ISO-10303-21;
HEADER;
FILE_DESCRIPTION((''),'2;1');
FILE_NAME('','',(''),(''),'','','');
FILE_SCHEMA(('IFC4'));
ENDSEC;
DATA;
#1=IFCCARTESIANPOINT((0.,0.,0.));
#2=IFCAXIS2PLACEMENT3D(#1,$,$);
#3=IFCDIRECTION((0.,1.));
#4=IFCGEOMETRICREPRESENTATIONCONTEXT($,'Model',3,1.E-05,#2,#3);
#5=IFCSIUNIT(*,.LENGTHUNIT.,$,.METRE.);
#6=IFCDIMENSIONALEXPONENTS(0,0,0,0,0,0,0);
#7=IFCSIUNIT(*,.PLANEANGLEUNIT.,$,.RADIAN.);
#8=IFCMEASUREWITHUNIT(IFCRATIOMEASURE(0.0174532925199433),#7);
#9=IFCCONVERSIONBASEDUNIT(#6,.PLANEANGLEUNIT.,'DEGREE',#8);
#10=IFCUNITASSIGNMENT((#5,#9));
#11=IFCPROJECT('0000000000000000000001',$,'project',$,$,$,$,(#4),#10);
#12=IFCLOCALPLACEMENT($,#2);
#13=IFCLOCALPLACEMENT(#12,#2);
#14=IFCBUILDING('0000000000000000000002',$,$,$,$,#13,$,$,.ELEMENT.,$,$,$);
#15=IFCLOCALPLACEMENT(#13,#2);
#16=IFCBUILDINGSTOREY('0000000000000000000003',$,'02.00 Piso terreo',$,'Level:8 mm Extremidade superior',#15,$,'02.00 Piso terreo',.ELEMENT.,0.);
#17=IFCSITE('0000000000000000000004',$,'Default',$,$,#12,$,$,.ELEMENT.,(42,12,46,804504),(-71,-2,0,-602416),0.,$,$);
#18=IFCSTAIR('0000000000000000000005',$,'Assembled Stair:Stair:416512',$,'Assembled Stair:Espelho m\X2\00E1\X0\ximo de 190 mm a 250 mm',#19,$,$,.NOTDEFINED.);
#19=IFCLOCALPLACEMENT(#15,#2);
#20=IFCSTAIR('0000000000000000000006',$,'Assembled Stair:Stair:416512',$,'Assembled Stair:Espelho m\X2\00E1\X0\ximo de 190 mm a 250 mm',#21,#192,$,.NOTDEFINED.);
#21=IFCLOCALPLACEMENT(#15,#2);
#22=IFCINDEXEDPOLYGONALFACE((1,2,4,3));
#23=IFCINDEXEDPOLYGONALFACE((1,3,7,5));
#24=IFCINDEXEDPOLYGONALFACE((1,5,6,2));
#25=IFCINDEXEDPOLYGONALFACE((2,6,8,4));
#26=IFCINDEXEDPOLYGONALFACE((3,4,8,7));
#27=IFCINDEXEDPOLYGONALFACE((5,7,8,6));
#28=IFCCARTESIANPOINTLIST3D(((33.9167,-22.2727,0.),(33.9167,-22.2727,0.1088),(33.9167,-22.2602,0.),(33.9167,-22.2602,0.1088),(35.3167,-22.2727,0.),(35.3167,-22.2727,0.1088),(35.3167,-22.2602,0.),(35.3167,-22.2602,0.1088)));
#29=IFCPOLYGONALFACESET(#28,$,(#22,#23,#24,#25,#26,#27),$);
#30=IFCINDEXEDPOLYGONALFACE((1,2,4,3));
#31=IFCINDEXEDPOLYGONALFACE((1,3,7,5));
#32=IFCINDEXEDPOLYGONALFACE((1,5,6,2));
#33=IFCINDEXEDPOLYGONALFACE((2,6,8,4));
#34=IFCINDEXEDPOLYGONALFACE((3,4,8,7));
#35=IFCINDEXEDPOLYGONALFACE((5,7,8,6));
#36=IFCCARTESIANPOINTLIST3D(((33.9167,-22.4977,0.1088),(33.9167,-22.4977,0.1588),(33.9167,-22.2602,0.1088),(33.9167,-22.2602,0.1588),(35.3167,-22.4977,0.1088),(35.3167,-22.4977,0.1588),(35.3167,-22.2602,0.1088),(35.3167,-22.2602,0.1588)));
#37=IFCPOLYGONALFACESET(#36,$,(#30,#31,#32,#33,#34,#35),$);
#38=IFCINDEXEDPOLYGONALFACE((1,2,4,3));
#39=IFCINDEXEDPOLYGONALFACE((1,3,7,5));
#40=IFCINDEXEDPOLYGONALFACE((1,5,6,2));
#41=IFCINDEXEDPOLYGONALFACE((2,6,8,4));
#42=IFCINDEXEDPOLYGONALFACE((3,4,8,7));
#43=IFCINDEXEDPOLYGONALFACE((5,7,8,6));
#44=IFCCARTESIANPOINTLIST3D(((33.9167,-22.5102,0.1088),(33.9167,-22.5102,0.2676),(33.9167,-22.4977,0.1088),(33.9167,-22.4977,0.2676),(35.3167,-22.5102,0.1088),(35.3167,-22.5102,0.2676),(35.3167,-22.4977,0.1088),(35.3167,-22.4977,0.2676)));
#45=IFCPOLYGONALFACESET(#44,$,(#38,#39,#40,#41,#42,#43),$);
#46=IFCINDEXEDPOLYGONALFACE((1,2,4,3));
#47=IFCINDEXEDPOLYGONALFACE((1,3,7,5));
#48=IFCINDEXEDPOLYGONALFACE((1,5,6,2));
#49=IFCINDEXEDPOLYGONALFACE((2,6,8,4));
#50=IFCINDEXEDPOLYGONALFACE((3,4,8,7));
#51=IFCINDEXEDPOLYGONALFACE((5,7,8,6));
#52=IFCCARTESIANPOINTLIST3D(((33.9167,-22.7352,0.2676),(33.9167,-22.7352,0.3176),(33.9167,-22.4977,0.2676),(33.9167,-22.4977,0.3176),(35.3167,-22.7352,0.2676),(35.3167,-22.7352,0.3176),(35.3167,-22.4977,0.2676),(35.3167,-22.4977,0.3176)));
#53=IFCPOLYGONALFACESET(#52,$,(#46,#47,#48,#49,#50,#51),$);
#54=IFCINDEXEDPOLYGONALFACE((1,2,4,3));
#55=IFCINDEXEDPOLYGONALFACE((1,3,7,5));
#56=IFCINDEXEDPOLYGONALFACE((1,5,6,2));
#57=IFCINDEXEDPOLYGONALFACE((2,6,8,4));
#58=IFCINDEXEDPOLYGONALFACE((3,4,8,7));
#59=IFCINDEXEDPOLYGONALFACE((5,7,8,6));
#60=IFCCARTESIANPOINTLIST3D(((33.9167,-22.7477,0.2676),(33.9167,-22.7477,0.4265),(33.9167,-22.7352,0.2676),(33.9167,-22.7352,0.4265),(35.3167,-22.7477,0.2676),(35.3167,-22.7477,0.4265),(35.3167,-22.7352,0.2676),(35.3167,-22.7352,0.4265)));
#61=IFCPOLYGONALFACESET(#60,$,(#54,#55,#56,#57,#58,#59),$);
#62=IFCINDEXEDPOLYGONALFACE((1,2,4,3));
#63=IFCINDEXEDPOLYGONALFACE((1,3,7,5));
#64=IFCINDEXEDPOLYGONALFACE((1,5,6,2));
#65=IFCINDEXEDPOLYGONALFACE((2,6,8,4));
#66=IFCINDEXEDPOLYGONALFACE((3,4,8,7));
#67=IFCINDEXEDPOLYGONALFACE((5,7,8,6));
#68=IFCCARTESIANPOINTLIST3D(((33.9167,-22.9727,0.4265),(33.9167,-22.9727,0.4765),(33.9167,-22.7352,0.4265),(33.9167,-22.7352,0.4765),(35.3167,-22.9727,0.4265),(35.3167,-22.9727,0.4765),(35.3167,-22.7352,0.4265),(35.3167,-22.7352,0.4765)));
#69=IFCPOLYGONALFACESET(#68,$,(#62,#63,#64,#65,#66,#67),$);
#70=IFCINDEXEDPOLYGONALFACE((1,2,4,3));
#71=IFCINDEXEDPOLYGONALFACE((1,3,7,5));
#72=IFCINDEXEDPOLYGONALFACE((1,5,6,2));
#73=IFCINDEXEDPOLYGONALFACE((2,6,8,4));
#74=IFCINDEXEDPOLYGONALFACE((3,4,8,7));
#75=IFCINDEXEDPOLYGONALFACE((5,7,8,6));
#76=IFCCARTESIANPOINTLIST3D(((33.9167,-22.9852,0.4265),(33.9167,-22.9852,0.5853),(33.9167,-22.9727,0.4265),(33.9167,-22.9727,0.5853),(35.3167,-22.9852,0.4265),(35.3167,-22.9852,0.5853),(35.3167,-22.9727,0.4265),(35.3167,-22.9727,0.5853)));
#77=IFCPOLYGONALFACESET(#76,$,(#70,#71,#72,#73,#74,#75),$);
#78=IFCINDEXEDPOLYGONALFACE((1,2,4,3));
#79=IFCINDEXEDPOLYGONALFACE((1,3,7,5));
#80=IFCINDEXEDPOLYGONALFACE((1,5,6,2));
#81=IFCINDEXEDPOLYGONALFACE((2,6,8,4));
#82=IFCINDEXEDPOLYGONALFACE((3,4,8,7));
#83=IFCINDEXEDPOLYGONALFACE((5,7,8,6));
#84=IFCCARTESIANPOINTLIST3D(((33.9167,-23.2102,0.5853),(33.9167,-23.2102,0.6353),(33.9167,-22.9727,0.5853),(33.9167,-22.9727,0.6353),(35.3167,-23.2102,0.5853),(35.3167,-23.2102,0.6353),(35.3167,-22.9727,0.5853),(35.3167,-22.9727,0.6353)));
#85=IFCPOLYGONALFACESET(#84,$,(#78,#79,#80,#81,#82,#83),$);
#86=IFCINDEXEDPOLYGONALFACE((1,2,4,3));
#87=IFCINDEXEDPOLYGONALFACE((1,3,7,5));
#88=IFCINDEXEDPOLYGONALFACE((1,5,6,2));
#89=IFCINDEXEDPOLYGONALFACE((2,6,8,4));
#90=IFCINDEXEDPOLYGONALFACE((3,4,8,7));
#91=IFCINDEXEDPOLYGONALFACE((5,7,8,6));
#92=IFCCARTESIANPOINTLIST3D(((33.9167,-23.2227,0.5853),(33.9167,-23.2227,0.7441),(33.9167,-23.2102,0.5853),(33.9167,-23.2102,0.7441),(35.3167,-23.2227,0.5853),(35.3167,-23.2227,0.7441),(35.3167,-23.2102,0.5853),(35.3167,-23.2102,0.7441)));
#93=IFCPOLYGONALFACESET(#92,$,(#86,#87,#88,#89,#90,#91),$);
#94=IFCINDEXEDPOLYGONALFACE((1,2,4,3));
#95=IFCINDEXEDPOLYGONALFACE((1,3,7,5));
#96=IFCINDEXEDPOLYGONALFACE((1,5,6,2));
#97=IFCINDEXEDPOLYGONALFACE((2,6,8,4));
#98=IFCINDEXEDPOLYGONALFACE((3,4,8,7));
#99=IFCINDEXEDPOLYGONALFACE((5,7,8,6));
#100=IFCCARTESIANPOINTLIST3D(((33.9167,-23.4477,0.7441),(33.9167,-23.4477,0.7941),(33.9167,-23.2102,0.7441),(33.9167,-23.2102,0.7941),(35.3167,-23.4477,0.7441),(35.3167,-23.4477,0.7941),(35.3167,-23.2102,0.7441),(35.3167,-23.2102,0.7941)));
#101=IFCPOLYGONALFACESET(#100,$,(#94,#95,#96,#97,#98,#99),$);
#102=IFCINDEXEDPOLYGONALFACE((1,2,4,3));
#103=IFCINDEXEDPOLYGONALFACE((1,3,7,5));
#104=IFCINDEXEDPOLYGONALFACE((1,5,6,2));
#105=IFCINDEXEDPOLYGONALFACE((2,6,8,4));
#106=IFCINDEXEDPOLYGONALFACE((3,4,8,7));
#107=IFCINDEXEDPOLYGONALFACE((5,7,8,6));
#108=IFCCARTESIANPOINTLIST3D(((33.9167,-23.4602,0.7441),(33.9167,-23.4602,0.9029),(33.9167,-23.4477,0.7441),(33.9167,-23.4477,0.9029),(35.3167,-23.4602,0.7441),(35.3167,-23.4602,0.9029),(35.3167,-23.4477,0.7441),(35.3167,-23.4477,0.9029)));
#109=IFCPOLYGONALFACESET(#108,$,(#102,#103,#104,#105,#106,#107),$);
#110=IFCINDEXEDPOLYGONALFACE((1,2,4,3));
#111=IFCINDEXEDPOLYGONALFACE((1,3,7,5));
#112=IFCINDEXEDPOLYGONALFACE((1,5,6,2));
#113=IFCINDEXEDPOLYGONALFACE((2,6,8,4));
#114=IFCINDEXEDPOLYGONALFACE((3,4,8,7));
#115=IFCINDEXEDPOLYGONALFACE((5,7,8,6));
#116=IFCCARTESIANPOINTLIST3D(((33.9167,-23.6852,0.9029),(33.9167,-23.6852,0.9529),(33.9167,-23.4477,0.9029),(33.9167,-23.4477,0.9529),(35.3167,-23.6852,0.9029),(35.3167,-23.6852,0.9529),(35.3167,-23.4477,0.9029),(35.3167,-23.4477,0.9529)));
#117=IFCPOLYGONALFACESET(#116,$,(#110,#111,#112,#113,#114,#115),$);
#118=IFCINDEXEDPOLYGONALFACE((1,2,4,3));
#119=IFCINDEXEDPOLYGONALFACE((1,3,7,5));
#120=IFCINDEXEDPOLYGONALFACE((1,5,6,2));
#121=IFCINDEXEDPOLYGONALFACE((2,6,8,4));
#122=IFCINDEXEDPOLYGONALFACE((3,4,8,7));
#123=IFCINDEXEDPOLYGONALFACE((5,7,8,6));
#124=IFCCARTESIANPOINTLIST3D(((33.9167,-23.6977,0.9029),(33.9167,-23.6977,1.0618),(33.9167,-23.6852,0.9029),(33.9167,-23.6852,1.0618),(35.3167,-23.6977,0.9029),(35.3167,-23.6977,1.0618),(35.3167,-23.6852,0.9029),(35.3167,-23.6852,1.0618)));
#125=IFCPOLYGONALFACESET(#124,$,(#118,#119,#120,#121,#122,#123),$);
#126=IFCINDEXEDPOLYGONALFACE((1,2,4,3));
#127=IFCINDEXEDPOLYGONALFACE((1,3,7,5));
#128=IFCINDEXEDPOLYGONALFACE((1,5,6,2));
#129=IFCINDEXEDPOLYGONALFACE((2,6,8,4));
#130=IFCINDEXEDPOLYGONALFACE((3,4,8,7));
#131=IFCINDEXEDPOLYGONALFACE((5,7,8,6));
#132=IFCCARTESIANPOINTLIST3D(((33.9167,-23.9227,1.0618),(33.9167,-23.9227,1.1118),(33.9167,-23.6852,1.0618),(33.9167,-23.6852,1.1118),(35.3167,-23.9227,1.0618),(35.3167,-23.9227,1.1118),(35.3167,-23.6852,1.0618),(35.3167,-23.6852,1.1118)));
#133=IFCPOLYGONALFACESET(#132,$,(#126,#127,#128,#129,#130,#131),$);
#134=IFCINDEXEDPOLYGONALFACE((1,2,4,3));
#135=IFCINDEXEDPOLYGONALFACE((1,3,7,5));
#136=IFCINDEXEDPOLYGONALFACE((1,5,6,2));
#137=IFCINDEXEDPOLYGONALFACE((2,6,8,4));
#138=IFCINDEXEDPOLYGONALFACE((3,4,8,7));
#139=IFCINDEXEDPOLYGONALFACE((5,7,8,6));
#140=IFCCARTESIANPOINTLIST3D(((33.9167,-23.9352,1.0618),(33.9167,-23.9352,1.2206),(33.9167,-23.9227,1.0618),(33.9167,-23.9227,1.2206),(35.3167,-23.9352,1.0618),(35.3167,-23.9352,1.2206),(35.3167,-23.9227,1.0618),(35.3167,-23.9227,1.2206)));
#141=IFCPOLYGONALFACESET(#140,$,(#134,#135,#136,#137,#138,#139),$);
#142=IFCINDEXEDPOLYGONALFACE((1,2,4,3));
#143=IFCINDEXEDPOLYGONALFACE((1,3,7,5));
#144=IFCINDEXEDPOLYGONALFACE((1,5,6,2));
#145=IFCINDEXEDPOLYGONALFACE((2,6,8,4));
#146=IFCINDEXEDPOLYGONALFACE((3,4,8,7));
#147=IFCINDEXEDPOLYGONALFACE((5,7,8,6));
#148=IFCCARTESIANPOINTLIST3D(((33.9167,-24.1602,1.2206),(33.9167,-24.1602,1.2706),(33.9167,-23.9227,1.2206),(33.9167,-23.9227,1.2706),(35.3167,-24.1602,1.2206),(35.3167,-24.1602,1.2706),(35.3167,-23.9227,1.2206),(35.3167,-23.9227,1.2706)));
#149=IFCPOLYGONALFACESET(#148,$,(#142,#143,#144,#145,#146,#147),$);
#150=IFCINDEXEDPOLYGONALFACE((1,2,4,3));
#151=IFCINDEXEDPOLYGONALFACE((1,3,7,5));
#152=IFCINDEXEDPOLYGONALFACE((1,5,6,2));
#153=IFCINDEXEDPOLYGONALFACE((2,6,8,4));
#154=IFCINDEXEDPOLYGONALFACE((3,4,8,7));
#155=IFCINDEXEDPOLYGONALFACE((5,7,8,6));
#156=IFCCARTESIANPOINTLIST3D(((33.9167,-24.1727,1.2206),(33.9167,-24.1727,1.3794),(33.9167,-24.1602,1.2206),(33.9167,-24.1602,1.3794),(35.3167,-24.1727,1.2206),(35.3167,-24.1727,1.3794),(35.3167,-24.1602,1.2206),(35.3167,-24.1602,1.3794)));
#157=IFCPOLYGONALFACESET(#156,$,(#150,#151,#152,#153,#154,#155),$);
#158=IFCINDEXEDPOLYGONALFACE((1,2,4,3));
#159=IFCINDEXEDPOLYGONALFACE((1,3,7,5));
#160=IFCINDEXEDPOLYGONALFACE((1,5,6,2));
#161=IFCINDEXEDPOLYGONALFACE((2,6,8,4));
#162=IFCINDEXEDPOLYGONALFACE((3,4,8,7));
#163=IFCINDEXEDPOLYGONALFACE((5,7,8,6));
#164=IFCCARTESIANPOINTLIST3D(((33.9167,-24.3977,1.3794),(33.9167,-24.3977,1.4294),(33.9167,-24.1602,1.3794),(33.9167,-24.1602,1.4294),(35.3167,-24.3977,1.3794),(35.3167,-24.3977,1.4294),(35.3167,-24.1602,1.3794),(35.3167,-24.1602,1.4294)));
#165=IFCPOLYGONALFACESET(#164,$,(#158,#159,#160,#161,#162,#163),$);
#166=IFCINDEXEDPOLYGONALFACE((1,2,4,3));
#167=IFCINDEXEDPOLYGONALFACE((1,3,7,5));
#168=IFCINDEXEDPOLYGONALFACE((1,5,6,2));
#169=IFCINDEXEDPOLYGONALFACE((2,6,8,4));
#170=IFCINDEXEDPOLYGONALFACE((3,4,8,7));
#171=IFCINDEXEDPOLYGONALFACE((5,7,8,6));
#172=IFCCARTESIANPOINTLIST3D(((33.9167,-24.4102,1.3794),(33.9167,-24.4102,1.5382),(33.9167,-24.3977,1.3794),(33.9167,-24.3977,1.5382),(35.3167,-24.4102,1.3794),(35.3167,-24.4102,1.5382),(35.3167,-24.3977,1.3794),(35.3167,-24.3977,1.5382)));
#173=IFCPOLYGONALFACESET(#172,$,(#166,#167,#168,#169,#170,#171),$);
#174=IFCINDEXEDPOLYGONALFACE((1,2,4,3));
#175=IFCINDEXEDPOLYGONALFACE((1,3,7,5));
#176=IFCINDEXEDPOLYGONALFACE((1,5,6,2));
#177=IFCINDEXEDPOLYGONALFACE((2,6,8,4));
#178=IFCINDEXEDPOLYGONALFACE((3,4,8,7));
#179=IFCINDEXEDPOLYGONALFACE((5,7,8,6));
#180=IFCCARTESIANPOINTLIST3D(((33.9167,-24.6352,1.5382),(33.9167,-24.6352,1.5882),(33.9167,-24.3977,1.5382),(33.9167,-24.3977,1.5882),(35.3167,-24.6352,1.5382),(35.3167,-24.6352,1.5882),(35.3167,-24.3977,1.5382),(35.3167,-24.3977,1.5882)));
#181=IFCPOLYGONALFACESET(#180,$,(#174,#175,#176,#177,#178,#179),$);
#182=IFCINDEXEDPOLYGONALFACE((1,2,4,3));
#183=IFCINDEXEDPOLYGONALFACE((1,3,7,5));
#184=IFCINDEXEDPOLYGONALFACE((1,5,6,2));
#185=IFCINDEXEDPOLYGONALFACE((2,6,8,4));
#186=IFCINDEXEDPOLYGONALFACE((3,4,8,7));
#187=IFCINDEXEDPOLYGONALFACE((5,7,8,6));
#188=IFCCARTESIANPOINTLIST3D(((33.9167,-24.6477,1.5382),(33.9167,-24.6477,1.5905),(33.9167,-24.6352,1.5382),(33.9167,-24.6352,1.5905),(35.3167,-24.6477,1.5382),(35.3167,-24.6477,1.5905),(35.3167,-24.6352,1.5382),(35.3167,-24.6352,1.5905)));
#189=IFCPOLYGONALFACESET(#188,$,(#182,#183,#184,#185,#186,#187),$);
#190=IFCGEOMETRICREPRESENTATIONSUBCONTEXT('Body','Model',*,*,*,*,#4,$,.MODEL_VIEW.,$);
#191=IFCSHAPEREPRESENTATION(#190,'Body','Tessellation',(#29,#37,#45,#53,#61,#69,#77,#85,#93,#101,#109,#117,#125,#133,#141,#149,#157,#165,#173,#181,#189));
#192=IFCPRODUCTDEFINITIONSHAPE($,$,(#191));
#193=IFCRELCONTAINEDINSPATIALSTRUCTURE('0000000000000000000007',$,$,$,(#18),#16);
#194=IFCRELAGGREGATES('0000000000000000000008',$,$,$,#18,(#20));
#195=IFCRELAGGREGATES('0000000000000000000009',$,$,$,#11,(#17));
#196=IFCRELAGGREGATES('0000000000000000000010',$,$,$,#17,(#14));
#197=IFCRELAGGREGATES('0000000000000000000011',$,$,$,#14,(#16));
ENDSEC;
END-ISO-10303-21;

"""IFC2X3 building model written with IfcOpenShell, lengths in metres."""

from ifc_helpers import new_model, entity, si_unit, converted_unit, direction, frame, frame_2d, origin, origin_2d_with_axis, place, context, subcontext, project, spatial, rectangle, extrude, element, aggregate, save


model = new_model("IFC2X3")

# Units and contexts
model_context = context("Model", 3, precision=1e-05, world=origin(), true_north=direction((0.0, 1.0)))
body_context = subcontext(model_context, "Body", "Model", "MODEL_VIEW")
ifc_project = project(units=[si_unit("LENGTHUNIT", "METRE"), converted_unit("PLANEANGLEUNIT", "DEGREE", entity("IfcRatioMeasure", 0.0174532925199433), si_unit("PLANEANGLEUNIT", "RADIAN"), dimensions=[0, 0, 0, 0, 0, 0, 0])], contexts=[model_context])

# Site, building, storey
site_placement = place(None, origin())
site = spatial("IfcSite", under=ifc_project, at=site_placement, Name="Default", CompositionType="ELEMENT", RefLatitude=(42, 12, 46, 804504), RefLongitude=(-71, -2, 0, -602416), RefElevation=0.0)
building_placement = place(site_placement, origin())
building = spatial("IfcBuilding", under=site, at=building_placement, CompositionType="ELEMENT")
storey_placement = place(building_placement, origin())
storey = spatial("IfcBuildingStorey", under=building, at=storey_placement, Name="02.00 Piso terreo", ObjectType="Level:8 mm Extremidade superior", LongName="02.00 Piso terreo", CompositionType="ELEMENT", Elevation=0.0)

# Stairs
stair_1_placement = place(storey_placement, frame((33.9167, -24.6477, 0.0)))
stair_1 = element("IfcStair", 1, at=stair_1_placement, inside=storey, Name="Assembled Stair:Stair:416512", ObjectType="Assembled Stair:Espelho máximo de 190 mm a 250 mm", ShapeType="NOTDEFINED")
stair_2_placement = place(stair_1_placement, origin())
stair_2 = element("IfcStair", 2, at=stair_2_placement, Name="Assembled Stair:Stair:416512", ObjectType="Assembled Stair:Espelho máximo de 190 mm a 250 mm", ShapeType="NOTDEFINED", context=body_context, shape_type="SweptSolid", body=[
    extrude(rectangle(XDim=1.4, YDim=0.0125, at=frame_2d((0.0, 0.0), x_axis=(1.0, 0.0))), frame((0.7, 2.3812, 0.0)), (0.0, 0.0, 1.0), 0.1088),
    extrude(rectangle(XDim=0.2375, YDim=1.4, at=origin_2d_with_axis()), frame((0.7, 2.2687, 0.1088), z_axis=(0.0, 0.0, 1.0), x_axis=(0.0, 1.0, 0.0)), (0.0, 0.0, 1.0), 0.05),
    extrude(rectangle(XDim=1.4, YDim=0.0125, at=frame_2d((0.0, 0.0), x_axis=(1.0, 0.0))), frame((0.7, 2.1437, 0.1088)), (0.0, 0.0, 1.0), 0.1588),
    extrude(rectangle(XDim=0.2375, YDim=1.4, at=frame_2d((0.0, 0.0), x_axis=(1.0, 0.0))), frame((0.7, 2.0312, 0.2676), z_axis=(0.0, 0.0, 1.0), x_axis=(0.0, 1.0, 0.0)), (0.0, 0.0, 1.0), 0.05),
    extrude(rectangle(XDim=1.4, YDim=0.0125, at=frame_2d((0.0, 0.0), x_axis=(1.0, 0.0))), frame((0.7, 1.9062, 0.2676)), (0.0, 0.0, 1.0), 0.1588),
    extrude(rectangle(XDim=0.2375, YDim=1.4, at=frame_2d((0.0, 0.0), x_axis=(1.0, 0.0))), frame((0.7, 1.7937, 0.4265), z_axis=(0.0, 0.0, 1.0), x_axis=(0.0, 1.0, 0.0)), (0.0, 0.0, 1.0), 0.05),
    extrude(rectangle(XDim=1.4, YDim=0.0125, at=frame_2d((0.0, 0.0), x_axis=(1.0, 0.0))), frame((0.7, 1.6687, 0.4265)), (0.0, 0.0, 1.0), 0.1588),
    extrude(rectangle(XDim=0.2375, YDim=1.4, at=frame_2d((0.0, 0.0), x_axis=(1.0, 0.0))), frame((0.7, 1.5562, 0.5853), z_axis=(0.0, 0.0, 1.0), x_axis=(0.0, 1.0, 0.0)), (0.0, 0.0, 1.0), 0.05),
    extrude(rectangle(XDim=1.4, YDim=0.0125, at=frame_2d((0.0, 0.0), x_axis=(1.0, 0.0))), frame((0.7, 1.4312, 0.5853)), (0.0, 0.0, 1.0), 0.1588),
    extrude(rectangle(XDim=0.2375, YDim=1.4, at=frame_2d((0.0, 0.0), x_axis=(1.0, 0.0))), frame((0.7, 1.3187, 0.7441), z_axis=(0.0, 0.0, 1.0), x_axis=(0.0, 1.0, 0.0)), (0.0, 0.0, 1.0), 0.05),
    extrude(rectangle(XDim=1.4, YDim=0.0125, at=frame_2d((0.0, 0.0), x_axis=(1.0, 0.0))), frame((0.7, 1.1938, 0.7441)), (0.0, 0.0, 1.0), 0.1588),
    extrude(rectangle(XDim=0.2375, YDim=1.4, at=frame_2d((0.0, 0.0), x_axis=(1.0, 0.0))), frame((0.7, 1.0813, 0.9029), z_axis=(0.0, 0.0, 1.0), x_axis=(0.0, 1.0, 0.0)), (0.0, 0.0, 1.0), 0.05),
    extrude(rectangle(XDim=1.4, YDim=0.0125, at=frame_2d((0.0, 0.0), x_axis=(1.0, 0.0))), frame((0.7, 0.9563, 0.9029)), (0.0, 0.0, 1.0), 0.1588),
    extrude(rectangle(XDim=0.2375, YDim=1.4, at=frame_2d((0.0, 0.0), x_axis=(1.0, 0.0))), frame((0.7, 0.8438, 1.0618), z_axis=(0.0, 0.0, 1.0), x_axis=(0.0, 1.0, 0.0)), (0.0, 0.0, 1.0), 0.05),
    extrude(rectangle(XDim=1.4, YDim=0.0125, at=frame_2d((0.0, 0.0), x_axis=(1.0, 0.0))), frame((0.7, 0.7187, 1.0618)), (0.0, 0.0, 1.0), 0.1588),
    extrude(rectangle(XDim=0.2375, YDim=1.4, at=frame_2d((0.0, 0.0), x_axis=(1.0, 0.0))), frame((0.7, 0.6062, 1.2206), z_axis=(0.0, 0.0, 1.0), x_axis=(0.0, 1.0, 0.0)), (0.0, 0.0, 1.0), 0.05),
    extrude(rectangle(XDim=1.4, YDim=0.0125, at=frame_2d((0.0, 0.0), x_axis=(1.0, 0.0))), frame((0.7, 0.4813, 1.2206)), (0.0, 0.0, 1.0), 0.1588),
    extrude(rectangle(XDim=0.2375, YDim=1.4, at=frame_2d((0.0, 0.0), x_axis=(1.0, 0.0))), frame((0.7, 0.3688, 1.3794), z_axis=(0.0, 0.0, 1.0), x_axis=(0.0, 1.0, 0.0)), (0.0, 0.0, 1.0), 0.05),
    extrude(rectangle(XDim=1.4, YDim=0.0125, at=frame_2d((0.0, 0.0), x_axis=(1.0, 0.0))), frame((0.7, 0.2438, 1.3794)), (0.0, 0.0, 1.0), 0.1588),
    extrude(rectangle(XDim=0.2375, YDim=1.4, at=frame_2d((0.0, 0.0), x_axis=(1.0, 0.0))), frame((0.7, 0.1313, 1.5382), z_axis=(0.0, 0.0, 1.0), x_axis=(0.0, 1.0, 0.0)), (0.0, 0.0, 1.0), 0.05),
    extrude(rectangle(XDim=1.4, YDim=0.0125, at=frame_2d((0.0, 0.0), x_axis=(1.0, 0.0))), frame((0.7, 0.0063, 1.5382)), (0.0, 0.0, 1.0), 0.0522),
])
aggregate(stair_1, [stair_2])

save(model, "model.ifc")
